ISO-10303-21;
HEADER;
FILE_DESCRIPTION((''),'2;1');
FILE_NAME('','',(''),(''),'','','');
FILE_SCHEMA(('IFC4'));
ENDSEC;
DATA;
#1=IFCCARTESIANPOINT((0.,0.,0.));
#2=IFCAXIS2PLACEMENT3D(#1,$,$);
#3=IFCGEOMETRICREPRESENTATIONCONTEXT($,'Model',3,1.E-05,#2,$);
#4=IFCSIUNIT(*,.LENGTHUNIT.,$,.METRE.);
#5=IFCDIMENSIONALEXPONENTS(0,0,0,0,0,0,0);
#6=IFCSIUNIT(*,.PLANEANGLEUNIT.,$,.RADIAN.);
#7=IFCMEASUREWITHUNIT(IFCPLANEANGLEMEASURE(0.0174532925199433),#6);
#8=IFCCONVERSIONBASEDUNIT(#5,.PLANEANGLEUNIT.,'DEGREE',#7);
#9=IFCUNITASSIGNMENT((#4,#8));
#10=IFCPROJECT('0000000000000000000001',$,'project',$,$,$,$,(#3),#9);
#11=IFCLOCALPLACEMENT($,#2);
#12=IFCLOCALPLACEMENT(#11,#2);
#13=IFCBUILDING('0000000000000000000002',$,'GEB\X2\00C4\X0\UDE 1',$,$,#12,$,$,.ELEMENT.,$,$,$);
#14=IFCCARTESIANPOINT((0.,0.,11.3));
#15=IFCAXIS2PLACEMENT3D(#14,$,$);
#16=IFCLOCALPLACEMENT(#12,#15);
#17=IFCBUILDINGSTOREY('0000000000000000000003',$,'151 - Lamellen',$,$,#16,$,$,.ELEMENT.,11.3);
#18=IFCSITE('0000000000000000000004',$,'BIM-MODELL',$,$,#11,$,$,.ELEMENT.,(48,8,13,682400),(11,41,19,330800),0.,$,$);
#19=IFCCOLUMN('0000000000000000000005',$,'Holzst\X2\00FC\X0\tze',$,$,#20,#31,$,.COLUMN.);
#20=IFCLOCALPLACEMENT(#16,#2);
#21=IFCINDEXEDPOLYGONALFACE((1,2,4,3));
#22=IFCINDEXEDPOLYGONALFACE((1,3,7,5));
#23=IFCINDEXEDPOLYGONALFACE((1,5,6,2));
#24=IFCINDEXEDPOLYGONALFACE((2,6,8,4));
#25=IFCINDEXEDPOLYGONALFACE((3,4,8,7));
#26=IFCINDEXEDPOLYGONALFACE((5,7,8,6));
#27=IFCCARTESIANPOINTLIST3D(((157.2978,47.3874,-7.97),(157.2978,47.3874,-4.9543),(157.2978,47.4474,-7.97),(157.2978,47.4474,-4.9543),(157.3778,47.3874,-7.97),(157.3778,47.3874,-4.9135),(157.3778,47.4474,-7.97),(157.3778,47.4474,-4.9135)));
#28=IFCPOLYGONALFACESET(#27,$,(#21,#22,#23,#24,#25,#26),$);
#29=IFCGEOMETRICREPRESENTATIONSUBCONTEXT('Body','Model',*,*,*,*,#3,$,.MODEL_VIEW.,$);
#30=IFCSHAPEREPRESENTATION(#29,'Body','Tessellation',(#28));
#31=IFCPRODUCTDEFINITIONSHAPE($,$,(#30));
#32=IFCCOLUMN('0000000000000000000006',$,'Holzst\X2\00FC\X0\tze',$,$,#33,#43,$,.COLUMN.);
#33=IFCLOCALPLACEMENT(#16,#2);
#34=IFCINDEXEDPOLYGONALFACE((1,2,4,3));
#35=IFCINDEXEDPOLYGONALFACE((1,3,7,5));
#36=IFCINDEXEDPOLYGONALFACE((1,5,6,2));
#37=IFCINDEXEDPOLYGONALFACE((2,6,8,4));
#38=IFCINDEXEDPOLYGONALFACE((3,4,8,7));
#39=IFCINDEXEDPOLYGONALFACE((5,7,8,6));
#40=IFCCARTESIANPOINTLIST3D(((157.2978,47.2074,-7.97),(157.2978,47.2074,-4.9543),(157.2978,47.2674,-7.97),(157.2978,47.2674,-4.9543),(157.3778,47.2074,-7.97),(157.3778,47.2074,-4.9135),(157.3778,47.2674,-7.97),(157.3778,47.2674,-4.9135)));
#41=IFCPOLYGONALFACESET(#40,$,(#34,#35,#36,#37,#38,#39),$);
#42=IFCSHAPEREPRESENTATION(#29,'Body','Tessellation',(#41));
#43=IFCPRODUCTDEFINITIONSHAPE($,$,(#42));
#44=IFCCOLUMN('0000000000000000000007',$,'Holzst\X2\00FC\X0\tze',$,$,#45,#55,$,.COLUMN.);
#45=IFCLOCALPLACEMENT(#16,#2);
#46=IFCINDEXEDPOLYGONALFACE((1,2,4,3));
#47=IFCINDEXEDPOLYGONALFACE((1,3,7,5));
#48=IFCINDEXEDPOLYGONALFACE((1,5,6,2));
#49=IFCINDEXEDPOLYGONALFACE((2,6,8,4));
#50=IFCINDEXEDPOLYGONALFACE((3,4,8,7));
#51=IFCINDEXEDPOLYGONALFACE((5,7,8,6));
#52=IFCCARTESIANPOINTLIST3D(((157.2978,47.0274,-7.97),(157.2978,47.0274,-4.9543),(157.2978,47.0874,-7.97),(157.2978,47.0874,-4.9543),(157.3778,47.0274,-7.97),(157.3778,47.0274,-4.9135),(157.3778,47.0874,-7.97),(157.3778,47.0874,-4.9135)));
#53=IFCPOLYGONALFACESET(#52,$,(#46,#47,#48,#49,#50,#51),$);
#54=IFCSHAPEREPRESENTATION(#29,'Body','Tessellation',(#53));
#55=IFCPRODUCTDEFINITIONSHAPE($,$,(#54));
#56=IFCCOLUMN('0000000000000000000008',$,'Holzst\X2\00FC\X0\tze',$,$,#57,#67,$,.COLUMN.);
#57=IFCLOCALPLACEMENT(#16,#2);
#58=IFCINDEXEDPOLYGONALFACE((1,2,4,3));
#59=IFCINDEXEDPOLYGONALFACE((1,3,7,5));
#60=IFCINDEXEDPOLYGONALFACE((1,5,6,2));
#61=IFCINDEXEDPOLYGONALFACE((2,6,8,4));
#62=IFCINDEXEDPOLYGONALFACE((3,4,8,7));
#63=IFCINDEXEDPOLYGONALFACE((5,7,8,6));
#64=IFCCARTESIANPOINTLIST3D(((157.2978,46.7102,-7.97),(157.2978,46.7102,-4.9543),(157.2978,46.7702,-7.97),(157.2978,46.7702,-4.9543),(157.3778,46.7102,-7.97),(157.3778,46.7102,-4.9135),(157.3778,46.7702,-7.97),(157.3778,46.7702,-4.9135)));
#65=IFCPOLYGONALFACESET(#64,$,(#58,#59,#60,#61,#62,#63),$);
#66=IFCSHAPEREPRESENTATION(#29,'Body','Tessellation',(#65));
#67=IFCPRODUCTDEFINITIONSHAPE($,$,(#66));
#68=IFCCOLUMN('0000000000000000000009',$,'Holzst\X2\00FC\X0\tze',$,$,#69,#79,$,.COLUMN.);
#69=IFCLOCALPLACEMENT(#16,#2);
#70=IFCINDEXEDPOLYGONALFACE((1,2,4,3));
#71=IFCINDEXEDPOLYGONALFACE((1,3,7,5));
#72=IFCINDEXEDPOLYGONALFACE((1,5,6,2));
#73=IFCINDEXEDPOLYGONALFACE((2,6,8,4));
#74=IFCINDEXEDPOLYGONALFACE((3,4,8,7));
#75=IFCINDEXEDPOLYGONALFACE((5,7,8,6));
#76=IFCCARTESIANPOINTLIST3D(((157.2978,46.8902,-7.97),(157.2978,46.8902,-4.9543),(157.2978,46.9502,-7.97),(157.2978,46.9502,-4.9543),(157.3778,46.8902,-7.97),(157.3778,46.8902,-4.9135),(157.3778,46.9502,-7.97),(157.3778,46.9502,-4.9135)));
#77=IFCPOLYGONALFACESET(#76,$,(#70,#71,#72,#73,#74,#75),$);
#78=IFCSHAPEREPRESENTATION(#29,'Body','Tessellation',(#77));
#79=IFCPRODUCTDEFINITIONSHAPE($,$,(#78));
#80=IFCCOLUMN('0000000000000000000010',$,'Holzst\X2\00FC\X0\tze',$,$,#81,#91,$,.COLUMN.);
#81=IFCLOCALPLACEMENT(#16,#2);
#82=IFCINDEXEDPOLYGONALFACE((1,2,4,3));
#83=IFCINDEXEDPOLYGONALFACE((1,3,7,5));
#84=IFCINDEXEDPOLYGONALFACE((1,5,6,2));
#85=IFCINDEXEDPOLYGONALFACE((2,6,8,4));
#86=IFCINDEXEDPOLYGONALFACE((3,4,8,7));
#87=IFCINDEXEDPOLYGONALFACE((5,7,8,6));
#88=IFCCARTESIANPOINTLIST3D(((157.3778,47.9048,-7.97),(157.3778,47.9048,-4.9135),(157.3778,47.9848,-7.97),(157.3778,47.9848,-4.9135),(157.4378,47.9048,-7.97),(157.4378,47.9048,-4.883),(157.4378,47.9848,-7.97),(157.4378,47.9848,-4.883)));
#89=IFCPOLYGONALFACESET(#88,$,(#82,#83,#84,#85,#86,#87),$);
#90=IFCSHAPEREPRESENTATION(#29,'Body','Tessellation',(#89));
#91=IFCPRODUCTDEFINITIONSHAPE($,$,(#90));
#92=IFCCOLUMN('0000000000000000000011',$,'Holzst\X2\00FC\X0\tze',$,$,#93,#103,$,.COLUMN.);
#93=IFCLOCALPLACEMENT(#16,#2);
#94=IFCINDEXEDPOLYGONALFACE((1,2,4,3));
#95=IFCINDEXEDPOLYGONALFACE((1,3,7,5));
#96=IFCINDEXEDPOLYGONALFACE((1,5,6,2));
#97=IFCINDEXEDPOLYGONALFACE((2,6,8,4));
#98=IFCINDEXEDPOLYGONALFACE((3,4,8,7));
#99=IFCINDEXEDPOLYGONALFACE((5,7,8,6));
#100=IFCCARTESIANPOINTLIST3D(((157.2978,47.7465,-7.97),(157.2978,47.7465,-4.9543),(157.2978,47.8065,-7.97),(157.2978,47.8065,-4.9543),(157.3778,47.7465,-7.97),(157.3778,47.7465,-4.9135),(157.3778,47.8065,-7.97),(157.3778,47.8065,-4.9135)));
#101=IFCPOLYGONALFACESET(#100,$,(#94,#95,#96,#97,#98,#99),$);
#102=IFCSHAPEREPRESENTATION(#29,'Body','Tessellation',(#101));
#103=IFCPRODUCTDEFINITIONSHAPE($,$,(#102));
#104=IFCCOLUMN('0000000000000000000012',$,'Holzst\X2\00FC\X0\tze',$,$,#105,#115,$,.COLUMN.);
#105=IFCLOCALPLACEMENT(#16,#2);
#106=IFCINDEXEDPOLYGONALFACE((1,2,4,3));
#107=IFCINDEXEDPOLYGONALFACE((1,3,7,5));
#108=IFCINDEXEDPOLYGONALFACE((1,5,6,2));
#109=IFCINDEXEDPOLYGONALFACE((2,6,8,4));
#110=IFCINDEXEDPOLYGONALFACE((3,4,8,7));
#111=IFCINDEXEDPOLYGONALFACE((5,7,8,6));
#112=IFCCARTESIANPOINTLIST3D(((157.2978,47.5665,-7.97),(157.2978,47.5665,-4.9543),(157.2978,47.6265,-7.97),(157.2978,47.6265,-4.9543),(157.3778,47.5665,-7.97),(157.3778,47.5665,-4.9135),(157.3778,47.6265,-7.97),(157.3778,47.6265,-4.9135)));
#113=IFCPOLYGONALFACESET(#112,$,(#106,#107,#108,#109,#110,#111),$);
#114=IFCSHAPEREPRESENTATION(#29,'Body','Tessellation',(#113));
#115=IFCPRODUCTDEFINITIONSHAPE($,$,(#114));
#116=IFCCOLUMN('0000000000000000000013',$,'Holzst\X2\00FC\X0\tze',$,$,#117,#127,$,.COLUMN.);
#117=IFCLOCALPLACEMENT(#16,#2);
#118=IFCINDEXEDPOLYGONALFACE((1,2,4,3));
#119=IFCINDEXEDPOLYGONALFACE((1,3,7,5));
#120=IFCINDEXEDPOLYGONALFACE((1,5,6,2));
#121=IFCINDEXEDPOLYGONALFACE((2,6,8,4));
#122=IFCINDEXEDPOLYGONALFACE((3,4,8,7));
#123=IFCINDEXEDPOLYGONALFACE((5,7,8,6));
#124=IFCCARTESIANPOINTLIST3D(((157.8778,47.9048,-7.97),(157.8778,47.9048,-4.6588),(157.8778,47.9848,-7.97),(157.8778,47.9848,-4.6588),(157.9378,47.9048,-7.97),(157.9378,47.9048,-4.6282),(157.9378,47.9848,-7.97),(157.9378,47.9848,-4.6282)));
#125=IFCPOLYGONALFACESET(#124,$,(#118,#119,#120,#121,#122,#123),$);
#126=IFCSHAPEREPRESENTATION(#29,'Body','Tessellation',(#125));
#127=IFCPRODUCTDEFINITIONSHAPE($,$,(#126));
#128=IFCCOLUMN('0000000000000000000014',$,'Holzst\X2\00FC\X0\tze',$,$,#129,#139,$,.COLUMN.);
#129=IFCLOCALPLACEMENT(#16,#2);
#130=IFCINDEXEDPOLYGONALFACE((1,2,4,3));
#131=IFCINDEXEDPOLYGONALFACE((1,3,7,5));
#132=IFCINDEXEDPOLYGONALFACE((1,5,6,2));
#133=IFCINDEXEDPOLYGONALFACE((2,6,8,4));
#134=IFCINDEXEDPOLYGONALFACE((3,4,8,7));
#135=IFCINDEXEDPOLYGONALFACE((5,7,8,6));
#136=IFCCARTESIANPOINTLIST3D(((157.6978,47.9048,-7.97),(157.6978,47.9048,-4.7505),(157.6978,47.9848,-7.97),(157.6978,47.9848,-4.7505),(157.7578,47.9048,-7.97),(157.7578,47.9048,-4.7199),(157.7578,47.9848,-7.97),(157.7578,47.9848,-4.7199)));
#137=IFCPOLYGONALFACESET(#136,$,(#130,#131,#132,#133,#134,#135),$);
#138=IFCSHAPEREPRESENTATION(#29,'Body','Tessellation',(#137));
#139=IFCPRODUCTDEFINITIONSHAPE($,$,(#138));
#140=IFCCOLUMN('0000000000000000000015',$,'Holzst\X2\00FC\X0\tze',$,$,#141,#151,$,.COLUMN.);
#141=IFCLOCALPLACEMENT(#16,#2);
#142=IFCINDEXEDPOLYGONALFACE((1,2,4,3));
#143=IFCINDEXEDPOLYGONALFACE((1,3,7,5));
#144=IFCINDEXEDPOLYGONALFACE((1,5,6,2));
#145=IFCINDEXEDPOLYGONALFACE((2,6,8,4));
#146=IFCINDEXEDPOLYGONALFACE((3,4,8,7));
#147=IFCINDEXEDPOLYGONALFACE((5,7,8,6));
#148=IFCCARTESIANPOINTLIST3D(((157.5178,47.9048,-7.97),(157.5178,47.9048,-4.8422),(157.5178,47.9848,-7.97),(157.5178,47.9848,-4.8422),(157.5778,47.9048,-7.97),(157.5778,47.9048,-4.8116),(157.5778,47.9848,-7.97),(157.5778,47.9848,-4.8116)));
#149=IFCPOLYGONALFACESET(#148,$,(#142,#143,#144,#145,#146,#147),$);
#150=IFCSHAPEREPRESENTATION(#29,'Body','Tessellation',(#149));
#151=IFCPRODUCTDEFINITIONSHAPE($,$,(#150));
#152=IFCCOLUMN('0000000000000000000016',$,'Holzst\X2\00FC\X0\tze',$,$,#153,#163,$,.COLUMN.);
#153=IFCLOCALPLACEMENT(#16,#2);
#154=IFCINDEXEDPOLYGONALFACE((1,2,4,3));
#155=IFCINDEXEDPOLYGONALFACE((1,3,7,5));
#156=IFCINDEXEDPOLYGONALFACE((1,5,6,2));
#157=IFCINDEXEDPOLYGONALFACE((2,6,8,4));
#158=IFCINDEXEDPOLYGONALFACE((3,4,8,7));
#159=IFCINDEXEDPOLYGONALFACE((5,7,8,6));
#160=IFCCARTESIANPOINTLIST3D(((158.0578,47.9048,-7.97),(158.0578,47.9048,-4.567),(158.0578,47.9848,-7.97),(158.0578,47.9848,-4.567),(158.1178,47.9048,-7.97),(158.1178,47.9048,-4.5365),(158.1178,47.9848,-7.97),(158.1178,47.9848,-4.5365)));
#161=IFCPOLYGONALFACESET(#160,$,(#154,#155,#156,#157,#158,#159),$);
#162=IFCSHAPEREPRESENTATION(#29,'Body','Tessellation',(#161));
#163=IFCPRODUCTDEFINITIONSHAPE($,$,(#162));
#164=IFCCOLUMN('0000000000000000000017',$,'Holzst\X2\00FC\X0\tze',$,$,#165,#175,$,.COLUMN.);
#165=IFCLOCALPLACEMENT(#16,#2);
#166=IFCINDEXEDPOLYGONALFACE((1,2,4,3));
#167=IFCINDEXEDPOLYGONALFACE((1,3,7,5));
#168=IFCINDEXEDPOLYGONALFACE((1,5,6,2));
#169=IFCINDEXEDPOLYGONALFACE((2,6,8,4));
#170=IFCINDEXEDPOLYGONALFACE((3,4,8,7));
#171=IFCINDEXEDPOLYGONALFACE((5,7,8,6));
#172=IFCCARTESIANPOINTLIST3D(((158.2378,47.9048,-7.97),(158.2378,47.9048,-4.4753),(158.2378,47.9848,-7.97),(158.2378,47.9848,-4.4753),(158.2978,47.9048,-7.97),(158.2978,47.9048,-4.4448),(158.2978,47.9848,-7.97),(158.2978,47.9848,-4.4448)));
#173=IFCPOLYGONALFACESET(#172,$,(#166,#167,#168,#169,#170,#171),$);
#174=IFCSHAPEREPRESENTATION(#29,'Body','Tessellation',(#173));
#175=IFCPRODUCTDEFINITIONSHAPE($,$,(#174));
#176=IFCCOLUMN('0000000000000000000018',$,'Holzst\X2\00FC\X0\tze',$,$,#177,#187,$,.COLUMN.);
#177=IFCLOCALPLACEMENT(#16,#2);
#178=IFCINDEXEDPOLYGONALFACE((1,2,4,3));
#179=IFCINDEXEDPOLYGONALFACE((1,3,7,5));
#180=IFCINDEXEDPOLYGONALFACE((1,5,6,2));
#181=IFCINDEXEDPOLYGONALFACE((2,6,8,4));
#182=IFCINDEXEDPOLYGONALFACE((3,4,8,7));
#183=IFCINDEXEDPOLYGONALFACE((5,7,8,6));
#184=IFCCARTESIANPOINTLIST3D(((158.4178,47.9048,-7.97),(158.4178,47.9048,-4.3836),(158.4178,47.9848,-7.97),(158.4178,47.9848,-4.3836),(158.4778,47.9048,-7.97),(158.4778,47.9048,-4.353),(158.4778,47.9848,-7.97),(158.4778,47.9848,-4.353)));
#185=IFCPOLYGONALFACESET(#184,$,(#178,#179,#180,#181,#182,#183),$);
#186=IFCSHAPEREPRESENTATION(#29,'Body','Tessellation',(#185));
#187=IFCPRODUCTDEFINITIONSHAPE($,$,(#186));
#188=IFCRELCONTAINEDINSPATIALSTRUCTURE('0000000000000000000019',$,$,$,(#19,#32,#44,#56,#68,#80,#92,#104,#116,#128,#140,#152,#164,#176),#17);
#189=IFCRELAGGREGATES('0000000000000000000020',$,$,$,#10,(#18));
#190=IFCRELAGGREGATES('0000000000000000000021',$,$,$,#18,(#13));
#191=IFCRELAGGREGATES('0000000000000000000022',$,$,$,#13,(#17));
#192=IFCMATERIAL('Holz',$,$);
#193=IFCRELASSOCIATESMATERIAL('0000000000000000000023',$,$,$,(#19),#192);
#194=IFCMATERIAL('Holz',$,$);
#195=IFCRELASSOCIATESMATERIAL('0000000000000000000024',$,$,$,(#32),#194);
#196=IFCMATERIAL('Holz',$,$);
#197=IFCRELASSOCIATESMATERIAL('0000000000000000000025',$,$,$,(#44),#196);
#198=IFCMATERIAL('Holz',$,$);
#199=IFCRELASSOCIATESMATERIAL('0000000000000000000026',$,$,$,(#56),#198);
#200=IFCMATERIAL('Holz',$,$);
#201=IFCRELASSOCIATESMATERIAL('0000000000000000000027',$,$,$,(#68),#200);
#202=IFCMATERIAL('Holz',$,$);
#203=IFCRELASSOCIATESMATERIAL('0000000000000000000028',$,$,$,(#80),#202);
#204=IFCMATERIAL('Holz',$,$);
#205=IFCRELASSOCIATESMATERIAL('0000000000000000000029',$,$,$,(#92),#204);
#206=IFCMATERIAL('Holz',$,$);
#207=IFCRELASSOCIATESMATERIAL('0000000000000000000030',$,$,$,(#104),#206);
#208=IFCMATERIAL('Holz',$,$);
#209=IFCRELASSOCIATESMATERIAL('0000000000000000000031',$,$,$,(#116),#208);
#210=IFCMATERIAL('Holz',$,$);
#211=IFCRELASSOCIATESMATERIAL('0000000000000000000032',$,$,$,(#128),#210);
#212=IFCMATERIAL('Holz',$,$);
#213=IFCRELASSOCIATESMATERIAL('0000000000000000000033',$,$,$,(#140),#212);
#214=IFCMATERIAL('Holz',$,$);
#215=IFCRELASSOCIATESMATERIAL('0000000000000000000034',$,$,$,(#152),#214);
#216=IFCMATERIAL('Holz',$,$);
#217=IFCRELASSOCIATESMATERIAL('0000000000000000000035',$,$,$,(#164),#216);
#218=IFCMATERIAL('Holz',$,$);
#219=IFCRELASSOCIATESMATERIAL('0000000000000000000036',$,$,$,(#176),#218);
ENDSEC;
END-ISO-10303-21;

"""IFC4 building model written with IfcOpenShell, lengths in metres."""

from ifc_helpers import new_model, entity, si_unit, converted_unit, frame, frame_2d, origin, origin_with_axes, place, context, subcontext, project, spatial, rectangle, extrude, clip, halfspace, material, element, save


model = new_model("IFC4")

# Units and contexts
model_context = context("Model", 3, precision=1e-05, world=origin())
body_context = subcontext(model_context, "Body", "Model", "MODEL_VIEW")
ifc_project = project(units=[si_unit("LENGTHUNIT", "METRE"), converted_unit("PLANEANGLEUNIT", "DEGREE", entity("IfcPlaneAngleMeasure", 0.0174532925199433), si_unit("PLANEANGLEUNIT", "RADIAN"), dimensions=[0, 0, 0, 0, 0, 0, 0])], contexts=[model_context])

# Site, building, storey
site_placement = place(None, origin())
site = spatial("IfcSite", under=ifc_project, at=site_placement, Name="BIM-MODELL", CompositionType="ELEMENT", RefLatitude=(48, 8, 13, 682400), RefLongitude=(11, 41, 19, 330800), RefElevation=0.0)
building_placement = place(site_placement, origin())
building = spatial("IfcBuilding", under=site, at=building_placement, Name="GEBÄUDE 1", CompositionType="ELEMENT")
storey_placement = place(building_placement, frame((0.0, 0.0, 11.3)))
storey = spatial("IfcBuildingStorey", under=building, at=storey_placement, Name="151 - Lamellen", CompositionType="ELEMENT", Elevation=11.3)

# Columns
ifc_material_1 = material(Name="Holz")
column_1_placement = place(storey_placement, frame((157.3778, 47.3874, -7.97)))
element("IfcColumn", 1, at=column_1_placement, inside=storey, material=ifc_material_1, Name="Holzstütze", PredefinedType="COLUMN", context=body_context, shape_type="Clipping", body=[
    clip(extrude(rectangle(XDim=0.06, YDim=0.08, at=frame_2d((-0.04, 0.03), x_axis=(0.0, 1.0))), origin_with_axes(), (0.0, 0.0, 1.0), 3.0565), halfspace(frame((-0.04, 0.03, 3.0361), z_axis=(0.45399, 0.0, -0.891007), x_axis=(-0.891007, 0.0, -0.45399)), True)),
])
ifc_material_2 = material(Name="Holz")
column_2_placement = place(storey_placement, frame((157.3778, 47.2074, -7.97)))
element("IfcColumn", 2, at=column_2_placement, inside=storey, material=ifc_material_2, Name="Holzstütze", PredefinedType="COLUMN", context=body_context, shape_type="Clipping", body=[
    clip(extrude(rectangle(XDim=0.06, YDim=0.08, at=frame_2d((-0.04, 0.03), x_axis=(0.0, 1.0))), origin_with_axes(), (0.0, 0.0, 1.0), 3.0565), halfspace(frame((-0.04, 0.03, 3.0361), z_axis=(0.45399, 0.0, -0.891007), x_axis=(-0.891007, 0.0, -0.45399)), True)),
])
ifc_material_3 = material(Name="Holz")
column_3_placement = place(storey_placement, frame((157.3778, 47.0274, -7.97)))
element("IfcColumn", 3, at=column_3_placement, inside=storey, material=ifc_material_3, Name="Holzstütze", PredefinedType="COLUMN", context=body_context, shape_type="Clipping", body=[
    clip(extrude(rectangle(XDim=0.06, YDim=0.08, at=frame_2d((-0.04, 0.03), x_axis=(0.0, 1.0))), origin_with_axes(), (0.0, 0.0, 1.0), 3.0565), halfspace(frame((-0.04, 0.03, 3.0361), z_axis=(0.45399, 0.0, -0.891007), x_axis=(-0.891007, 0.0, -0.45399)), True)),
])
ifc_material_4 = material(Name="Holz")
column_4_placement = place(storey_placement, frame((157.3778, 46.7102, -7.97)))
element("IfcColumn", 4, at=column_4_placement, inside=storey, material=ifc_material_4, Name="Holzstütze", PredefinedType="COLUMN", context=body_context, shape_type="Clipping", body=[
    clip(extrude(rectangle(XDim=0.06, YDim=0.08, at=frame_2d((-0.04, 0.03), x_axis=(0.0, 1.0))), origin_with_axes(), (0.0, 0.0, 1.0), 3.0565), halfspace(frame((-0.04, 0.03, 3.0361), z_axis=(0.45399, 0.0, -0.891007), x_axis=(-0.891007, 0.0, -0.45399)), True)),
])
ifc_material_5 = material(Name="Holz")
column_5_placement = place(storey_placement, frame((157.3778, 46.8902, -7.97)))
element("IfcColumn", 5, at=column_5_placement, inside=storey, material=ifc_material_5, Name="Holzstütze", PredefinedType="COLUMN", context=body_context, shape_type="Clipping", body=[
    clip(extrude(rectangle(XDim=0.06, YDim=0.08, at=frame_2d((-0.04, 0.03), x_axis=(0.0, 1.0))), origin_with_axes(), (0.0, 0.0, 1.0), 3.0565), halfspace(frame((-0.04, 0.03, 3.0361), z_axis=(0.45399, 0.0, -0.891007), x_axis=(-0.891007, 0.0, -0.45399)), True)),
])
ifc_material_6 = material(Name="Holz")
column_6_placement = place(storey_placement, frame((157.3778, 47.9048, -7.97)))
element("IfcColumn", 6, at=column_6_placement, inside=storey, material=ifc_material_6, Name="Holzstütze", PredefinedType="COLUMN", context=body_context, shape_type="Clipping", body=[
    clip(extrude(rectangle(XDim=0.06, YDim=0.08, at=frame_2d((0.03, 0.04), x_axis=(1.0, 0.0))), origin_with_axes(), (0.0, 0.0, 1.0), 3.087), halfspace(frame((0.03, 0.04, 3.0718), z_axis=(0.45399, 0.0, -0.891007), x_axis=(0.0, 1.0, 0.0)), True)),
])
ifc_material_7 = material(Name="Holz")
column_7_placement = place(storey_placement, frame((157.3778, 47.7465, -7.97)))
element("IfcColumn", 7, at=column_7_placement, inside=storey, material=ifc_material_7, Name="Holzstütze", PredefinedType="COLUMN", context=body_context, shape_type="Clipping", body=[
    clip(extrude(rectangle(XDim=0.06, YDim=0.08, at=frame_2d((-0.04, 0.03), x_axis=(0.0, 1.0))), origin_with_axes(), (0.0, 0.0, 1.0), 3.0565), halfspace(frame((-0.04, 0.03, 3.0361), z_axis=(0.45399, 0.0, -0.891007), x_axis=(-0.891007, 0.0, -0.45399)), True)),
])
ifc_material_8 = material(Name="Holz")
column_8_placement = place(storey_placement, frame((157.3778, 47.5665, -7.97)))
element("IfcColumn", 8, at=column_8_placement, inside=storey, material=ifc_material_8, Name="Holzstütze", PredefinedType="COLUMN", context=body_context, shape_type="Clipping", body=[
    clip(extrude(rectangle(XDim=0.06, YDim=0.08, at=frame_2d((-0.04, 0.03), x_axis=(0.0, 1.0))), origin_with_axes(), (0.0, 0.0, 1.0), 3.0565), halfspace(frame((-0.04, 0.03, 3.0361), z_axis=(0.45399, 0.0, -0.891007), x_axis=(-0.891007, 0.0, -0.45399)), True)),
])
ifc_material_9 = material(Name="Holz")
column_9_placement = place(storey_placement, frame((157.8778, 47.9048, -7.97)))
element("IfcColumn", 9, at=column_9_placement, inside=storey, material=ifc_material_9, Name="Holzstütze", PredefinedType="COLUMN", context=body_context, shape_type="Clipping", body=[
    clip(extrude(rectangle(XDim=0.06, YDim=0.08, at=frame_2d((0.03, 0.04), x_axis=(1.0, 0.0))), origin_with_axes(), (0.0, 0.0, 1.0), 3.3418), halfspace(frame((0.03, 0.04, 3.3265), z_axis=(0.45399, 0.0, -0.891007), x_axis=(0.0, 1.0, 0.0)), True)),
])
ifc_material_10 = material(Name="Holz")
column_10_placement = place(storey_placement, frame((157.6978, 47.9048, -7.97)))
element("IfcColumn", 10, at=column_10_placement, inside=storey, material=ifc_material_10, Name="Holzstütze", PredefinedType="COLUMN", context=body_context, shape_type="Clipping", body=[
    clip(extrude(rectangle(XDim=0.06, YDim=0.08, at=frame_2d((0.03, 0.04), x_axis=(1.0, 0.0))), origin_with_axes(), (0.0, 0.0, 1.0), 3.2501), halfspace(frame((0.03, 0.04, 3.2348), z_axis=(0.45399, 0.0, -0.891007), x_axis=(0.0, 1.0, 0.0)), True)),
])
ifc_material_11 = material(Name="Holz")
column_11_placement = place(storey_placement, frame((157.5178, 47.9048, -7.97)))
element("IfcColumn", 11, at=column_11_placement, inside=storey, material=ifc_material_11, Name="Holzstütze", PredefinedType="COLUMN", context=body_context, shape_type="Clipping", body=[
    clip(extrude(rectangle(XDim=0.06, YDim=0.08, at=frame_2d((0.03, 0.04), x_axis=(1.0, 0.0))), origin_with_axes(), (0.0, 0.0, 1.0), 3.1584), halfspace(frame((0.03, 0.04, 3.1431), z_axis=(0.45399, 0.0, -0.891007), x_axis=(0.0, 1.0, 0.0)), True)),
])
ifc_material_12 = material(Name="Holz")
column_12_placement = place(storey_placement, frame((158.0578, 47.9048, -7.97)))
element("IfcColumn", 12, at=column_12_placement, inside=storey, material=ifc_material_12, Name="Holzstütze", PredefinedType="COLUMN", context=body_context, shape_type="Clipping", body=[
    clip(extrude(rectangle(XDim=0.06, YDim=0.08, at=frame_2d((0.03, 0.04), x_axis=(1.0, 0.0))), origin_with_axes(), (0.0, 0.0, 1.0), 3.4335), halfspace(frame((0.03, 0.04, 3.4182), z_axis=(0.45399, 0.0, -0.891007), x_axis=(0.0, 1.0, 0.0)), True)),
])
ifc_material_13 = material(Name="Holz")
column_13_placement = place(storey_placement, frame((158.2378, 47.9048, -7.97)))
element("IfcColumn", 13, at=column_13_placement, inside=storey, material=ifc_material_13, Name="Holzstütze", PredefinedType="COLUMN", context=body_context, shape_type="Clipping", body=[
    clip(extrude(rectangle(XDim=0.06, YDim=0.08, at=frame_2d((0.03, 0.04), x_axis=(1.0, 0.0))), origin_with_axes(), (0.0, 0.0, 1.0), 3.5252), halfspace(frame((0.03, 0.04, 3.51), z_axis=(0.45399, 0.0, -0.891007), x_axis=(0.0, 1.0, 0.0)), True)),
])
ifc_material_14 = material(Name="Holz")
column_14_placement = place(storey_placement, frame((158.4178, 47.9048, -7.97)))
element("IfcColumn", 14, at=column_14_placement, inside=storey, material=ifc_material_14, Name="Holzstütze", PredefinedType="COLUMN", context=body_context, shape_type="Clipping", body=[
    clip(extrude(rectangle(XDim=0.06, YDim=0.08, at=frame_2d((0.03, 0.04), x_axis=(1.0, 0.0))), origin_with_axes(), (0.0, 0.0, 1.0), 3.617), halfspace(frame((0.03, 0.04, 3.6017), z_axis=(0.45399, 0.0, -0.891007), x_axis=(0.0, 1.0, 0.0)), True)),
])

save(model, "model.ifc")
